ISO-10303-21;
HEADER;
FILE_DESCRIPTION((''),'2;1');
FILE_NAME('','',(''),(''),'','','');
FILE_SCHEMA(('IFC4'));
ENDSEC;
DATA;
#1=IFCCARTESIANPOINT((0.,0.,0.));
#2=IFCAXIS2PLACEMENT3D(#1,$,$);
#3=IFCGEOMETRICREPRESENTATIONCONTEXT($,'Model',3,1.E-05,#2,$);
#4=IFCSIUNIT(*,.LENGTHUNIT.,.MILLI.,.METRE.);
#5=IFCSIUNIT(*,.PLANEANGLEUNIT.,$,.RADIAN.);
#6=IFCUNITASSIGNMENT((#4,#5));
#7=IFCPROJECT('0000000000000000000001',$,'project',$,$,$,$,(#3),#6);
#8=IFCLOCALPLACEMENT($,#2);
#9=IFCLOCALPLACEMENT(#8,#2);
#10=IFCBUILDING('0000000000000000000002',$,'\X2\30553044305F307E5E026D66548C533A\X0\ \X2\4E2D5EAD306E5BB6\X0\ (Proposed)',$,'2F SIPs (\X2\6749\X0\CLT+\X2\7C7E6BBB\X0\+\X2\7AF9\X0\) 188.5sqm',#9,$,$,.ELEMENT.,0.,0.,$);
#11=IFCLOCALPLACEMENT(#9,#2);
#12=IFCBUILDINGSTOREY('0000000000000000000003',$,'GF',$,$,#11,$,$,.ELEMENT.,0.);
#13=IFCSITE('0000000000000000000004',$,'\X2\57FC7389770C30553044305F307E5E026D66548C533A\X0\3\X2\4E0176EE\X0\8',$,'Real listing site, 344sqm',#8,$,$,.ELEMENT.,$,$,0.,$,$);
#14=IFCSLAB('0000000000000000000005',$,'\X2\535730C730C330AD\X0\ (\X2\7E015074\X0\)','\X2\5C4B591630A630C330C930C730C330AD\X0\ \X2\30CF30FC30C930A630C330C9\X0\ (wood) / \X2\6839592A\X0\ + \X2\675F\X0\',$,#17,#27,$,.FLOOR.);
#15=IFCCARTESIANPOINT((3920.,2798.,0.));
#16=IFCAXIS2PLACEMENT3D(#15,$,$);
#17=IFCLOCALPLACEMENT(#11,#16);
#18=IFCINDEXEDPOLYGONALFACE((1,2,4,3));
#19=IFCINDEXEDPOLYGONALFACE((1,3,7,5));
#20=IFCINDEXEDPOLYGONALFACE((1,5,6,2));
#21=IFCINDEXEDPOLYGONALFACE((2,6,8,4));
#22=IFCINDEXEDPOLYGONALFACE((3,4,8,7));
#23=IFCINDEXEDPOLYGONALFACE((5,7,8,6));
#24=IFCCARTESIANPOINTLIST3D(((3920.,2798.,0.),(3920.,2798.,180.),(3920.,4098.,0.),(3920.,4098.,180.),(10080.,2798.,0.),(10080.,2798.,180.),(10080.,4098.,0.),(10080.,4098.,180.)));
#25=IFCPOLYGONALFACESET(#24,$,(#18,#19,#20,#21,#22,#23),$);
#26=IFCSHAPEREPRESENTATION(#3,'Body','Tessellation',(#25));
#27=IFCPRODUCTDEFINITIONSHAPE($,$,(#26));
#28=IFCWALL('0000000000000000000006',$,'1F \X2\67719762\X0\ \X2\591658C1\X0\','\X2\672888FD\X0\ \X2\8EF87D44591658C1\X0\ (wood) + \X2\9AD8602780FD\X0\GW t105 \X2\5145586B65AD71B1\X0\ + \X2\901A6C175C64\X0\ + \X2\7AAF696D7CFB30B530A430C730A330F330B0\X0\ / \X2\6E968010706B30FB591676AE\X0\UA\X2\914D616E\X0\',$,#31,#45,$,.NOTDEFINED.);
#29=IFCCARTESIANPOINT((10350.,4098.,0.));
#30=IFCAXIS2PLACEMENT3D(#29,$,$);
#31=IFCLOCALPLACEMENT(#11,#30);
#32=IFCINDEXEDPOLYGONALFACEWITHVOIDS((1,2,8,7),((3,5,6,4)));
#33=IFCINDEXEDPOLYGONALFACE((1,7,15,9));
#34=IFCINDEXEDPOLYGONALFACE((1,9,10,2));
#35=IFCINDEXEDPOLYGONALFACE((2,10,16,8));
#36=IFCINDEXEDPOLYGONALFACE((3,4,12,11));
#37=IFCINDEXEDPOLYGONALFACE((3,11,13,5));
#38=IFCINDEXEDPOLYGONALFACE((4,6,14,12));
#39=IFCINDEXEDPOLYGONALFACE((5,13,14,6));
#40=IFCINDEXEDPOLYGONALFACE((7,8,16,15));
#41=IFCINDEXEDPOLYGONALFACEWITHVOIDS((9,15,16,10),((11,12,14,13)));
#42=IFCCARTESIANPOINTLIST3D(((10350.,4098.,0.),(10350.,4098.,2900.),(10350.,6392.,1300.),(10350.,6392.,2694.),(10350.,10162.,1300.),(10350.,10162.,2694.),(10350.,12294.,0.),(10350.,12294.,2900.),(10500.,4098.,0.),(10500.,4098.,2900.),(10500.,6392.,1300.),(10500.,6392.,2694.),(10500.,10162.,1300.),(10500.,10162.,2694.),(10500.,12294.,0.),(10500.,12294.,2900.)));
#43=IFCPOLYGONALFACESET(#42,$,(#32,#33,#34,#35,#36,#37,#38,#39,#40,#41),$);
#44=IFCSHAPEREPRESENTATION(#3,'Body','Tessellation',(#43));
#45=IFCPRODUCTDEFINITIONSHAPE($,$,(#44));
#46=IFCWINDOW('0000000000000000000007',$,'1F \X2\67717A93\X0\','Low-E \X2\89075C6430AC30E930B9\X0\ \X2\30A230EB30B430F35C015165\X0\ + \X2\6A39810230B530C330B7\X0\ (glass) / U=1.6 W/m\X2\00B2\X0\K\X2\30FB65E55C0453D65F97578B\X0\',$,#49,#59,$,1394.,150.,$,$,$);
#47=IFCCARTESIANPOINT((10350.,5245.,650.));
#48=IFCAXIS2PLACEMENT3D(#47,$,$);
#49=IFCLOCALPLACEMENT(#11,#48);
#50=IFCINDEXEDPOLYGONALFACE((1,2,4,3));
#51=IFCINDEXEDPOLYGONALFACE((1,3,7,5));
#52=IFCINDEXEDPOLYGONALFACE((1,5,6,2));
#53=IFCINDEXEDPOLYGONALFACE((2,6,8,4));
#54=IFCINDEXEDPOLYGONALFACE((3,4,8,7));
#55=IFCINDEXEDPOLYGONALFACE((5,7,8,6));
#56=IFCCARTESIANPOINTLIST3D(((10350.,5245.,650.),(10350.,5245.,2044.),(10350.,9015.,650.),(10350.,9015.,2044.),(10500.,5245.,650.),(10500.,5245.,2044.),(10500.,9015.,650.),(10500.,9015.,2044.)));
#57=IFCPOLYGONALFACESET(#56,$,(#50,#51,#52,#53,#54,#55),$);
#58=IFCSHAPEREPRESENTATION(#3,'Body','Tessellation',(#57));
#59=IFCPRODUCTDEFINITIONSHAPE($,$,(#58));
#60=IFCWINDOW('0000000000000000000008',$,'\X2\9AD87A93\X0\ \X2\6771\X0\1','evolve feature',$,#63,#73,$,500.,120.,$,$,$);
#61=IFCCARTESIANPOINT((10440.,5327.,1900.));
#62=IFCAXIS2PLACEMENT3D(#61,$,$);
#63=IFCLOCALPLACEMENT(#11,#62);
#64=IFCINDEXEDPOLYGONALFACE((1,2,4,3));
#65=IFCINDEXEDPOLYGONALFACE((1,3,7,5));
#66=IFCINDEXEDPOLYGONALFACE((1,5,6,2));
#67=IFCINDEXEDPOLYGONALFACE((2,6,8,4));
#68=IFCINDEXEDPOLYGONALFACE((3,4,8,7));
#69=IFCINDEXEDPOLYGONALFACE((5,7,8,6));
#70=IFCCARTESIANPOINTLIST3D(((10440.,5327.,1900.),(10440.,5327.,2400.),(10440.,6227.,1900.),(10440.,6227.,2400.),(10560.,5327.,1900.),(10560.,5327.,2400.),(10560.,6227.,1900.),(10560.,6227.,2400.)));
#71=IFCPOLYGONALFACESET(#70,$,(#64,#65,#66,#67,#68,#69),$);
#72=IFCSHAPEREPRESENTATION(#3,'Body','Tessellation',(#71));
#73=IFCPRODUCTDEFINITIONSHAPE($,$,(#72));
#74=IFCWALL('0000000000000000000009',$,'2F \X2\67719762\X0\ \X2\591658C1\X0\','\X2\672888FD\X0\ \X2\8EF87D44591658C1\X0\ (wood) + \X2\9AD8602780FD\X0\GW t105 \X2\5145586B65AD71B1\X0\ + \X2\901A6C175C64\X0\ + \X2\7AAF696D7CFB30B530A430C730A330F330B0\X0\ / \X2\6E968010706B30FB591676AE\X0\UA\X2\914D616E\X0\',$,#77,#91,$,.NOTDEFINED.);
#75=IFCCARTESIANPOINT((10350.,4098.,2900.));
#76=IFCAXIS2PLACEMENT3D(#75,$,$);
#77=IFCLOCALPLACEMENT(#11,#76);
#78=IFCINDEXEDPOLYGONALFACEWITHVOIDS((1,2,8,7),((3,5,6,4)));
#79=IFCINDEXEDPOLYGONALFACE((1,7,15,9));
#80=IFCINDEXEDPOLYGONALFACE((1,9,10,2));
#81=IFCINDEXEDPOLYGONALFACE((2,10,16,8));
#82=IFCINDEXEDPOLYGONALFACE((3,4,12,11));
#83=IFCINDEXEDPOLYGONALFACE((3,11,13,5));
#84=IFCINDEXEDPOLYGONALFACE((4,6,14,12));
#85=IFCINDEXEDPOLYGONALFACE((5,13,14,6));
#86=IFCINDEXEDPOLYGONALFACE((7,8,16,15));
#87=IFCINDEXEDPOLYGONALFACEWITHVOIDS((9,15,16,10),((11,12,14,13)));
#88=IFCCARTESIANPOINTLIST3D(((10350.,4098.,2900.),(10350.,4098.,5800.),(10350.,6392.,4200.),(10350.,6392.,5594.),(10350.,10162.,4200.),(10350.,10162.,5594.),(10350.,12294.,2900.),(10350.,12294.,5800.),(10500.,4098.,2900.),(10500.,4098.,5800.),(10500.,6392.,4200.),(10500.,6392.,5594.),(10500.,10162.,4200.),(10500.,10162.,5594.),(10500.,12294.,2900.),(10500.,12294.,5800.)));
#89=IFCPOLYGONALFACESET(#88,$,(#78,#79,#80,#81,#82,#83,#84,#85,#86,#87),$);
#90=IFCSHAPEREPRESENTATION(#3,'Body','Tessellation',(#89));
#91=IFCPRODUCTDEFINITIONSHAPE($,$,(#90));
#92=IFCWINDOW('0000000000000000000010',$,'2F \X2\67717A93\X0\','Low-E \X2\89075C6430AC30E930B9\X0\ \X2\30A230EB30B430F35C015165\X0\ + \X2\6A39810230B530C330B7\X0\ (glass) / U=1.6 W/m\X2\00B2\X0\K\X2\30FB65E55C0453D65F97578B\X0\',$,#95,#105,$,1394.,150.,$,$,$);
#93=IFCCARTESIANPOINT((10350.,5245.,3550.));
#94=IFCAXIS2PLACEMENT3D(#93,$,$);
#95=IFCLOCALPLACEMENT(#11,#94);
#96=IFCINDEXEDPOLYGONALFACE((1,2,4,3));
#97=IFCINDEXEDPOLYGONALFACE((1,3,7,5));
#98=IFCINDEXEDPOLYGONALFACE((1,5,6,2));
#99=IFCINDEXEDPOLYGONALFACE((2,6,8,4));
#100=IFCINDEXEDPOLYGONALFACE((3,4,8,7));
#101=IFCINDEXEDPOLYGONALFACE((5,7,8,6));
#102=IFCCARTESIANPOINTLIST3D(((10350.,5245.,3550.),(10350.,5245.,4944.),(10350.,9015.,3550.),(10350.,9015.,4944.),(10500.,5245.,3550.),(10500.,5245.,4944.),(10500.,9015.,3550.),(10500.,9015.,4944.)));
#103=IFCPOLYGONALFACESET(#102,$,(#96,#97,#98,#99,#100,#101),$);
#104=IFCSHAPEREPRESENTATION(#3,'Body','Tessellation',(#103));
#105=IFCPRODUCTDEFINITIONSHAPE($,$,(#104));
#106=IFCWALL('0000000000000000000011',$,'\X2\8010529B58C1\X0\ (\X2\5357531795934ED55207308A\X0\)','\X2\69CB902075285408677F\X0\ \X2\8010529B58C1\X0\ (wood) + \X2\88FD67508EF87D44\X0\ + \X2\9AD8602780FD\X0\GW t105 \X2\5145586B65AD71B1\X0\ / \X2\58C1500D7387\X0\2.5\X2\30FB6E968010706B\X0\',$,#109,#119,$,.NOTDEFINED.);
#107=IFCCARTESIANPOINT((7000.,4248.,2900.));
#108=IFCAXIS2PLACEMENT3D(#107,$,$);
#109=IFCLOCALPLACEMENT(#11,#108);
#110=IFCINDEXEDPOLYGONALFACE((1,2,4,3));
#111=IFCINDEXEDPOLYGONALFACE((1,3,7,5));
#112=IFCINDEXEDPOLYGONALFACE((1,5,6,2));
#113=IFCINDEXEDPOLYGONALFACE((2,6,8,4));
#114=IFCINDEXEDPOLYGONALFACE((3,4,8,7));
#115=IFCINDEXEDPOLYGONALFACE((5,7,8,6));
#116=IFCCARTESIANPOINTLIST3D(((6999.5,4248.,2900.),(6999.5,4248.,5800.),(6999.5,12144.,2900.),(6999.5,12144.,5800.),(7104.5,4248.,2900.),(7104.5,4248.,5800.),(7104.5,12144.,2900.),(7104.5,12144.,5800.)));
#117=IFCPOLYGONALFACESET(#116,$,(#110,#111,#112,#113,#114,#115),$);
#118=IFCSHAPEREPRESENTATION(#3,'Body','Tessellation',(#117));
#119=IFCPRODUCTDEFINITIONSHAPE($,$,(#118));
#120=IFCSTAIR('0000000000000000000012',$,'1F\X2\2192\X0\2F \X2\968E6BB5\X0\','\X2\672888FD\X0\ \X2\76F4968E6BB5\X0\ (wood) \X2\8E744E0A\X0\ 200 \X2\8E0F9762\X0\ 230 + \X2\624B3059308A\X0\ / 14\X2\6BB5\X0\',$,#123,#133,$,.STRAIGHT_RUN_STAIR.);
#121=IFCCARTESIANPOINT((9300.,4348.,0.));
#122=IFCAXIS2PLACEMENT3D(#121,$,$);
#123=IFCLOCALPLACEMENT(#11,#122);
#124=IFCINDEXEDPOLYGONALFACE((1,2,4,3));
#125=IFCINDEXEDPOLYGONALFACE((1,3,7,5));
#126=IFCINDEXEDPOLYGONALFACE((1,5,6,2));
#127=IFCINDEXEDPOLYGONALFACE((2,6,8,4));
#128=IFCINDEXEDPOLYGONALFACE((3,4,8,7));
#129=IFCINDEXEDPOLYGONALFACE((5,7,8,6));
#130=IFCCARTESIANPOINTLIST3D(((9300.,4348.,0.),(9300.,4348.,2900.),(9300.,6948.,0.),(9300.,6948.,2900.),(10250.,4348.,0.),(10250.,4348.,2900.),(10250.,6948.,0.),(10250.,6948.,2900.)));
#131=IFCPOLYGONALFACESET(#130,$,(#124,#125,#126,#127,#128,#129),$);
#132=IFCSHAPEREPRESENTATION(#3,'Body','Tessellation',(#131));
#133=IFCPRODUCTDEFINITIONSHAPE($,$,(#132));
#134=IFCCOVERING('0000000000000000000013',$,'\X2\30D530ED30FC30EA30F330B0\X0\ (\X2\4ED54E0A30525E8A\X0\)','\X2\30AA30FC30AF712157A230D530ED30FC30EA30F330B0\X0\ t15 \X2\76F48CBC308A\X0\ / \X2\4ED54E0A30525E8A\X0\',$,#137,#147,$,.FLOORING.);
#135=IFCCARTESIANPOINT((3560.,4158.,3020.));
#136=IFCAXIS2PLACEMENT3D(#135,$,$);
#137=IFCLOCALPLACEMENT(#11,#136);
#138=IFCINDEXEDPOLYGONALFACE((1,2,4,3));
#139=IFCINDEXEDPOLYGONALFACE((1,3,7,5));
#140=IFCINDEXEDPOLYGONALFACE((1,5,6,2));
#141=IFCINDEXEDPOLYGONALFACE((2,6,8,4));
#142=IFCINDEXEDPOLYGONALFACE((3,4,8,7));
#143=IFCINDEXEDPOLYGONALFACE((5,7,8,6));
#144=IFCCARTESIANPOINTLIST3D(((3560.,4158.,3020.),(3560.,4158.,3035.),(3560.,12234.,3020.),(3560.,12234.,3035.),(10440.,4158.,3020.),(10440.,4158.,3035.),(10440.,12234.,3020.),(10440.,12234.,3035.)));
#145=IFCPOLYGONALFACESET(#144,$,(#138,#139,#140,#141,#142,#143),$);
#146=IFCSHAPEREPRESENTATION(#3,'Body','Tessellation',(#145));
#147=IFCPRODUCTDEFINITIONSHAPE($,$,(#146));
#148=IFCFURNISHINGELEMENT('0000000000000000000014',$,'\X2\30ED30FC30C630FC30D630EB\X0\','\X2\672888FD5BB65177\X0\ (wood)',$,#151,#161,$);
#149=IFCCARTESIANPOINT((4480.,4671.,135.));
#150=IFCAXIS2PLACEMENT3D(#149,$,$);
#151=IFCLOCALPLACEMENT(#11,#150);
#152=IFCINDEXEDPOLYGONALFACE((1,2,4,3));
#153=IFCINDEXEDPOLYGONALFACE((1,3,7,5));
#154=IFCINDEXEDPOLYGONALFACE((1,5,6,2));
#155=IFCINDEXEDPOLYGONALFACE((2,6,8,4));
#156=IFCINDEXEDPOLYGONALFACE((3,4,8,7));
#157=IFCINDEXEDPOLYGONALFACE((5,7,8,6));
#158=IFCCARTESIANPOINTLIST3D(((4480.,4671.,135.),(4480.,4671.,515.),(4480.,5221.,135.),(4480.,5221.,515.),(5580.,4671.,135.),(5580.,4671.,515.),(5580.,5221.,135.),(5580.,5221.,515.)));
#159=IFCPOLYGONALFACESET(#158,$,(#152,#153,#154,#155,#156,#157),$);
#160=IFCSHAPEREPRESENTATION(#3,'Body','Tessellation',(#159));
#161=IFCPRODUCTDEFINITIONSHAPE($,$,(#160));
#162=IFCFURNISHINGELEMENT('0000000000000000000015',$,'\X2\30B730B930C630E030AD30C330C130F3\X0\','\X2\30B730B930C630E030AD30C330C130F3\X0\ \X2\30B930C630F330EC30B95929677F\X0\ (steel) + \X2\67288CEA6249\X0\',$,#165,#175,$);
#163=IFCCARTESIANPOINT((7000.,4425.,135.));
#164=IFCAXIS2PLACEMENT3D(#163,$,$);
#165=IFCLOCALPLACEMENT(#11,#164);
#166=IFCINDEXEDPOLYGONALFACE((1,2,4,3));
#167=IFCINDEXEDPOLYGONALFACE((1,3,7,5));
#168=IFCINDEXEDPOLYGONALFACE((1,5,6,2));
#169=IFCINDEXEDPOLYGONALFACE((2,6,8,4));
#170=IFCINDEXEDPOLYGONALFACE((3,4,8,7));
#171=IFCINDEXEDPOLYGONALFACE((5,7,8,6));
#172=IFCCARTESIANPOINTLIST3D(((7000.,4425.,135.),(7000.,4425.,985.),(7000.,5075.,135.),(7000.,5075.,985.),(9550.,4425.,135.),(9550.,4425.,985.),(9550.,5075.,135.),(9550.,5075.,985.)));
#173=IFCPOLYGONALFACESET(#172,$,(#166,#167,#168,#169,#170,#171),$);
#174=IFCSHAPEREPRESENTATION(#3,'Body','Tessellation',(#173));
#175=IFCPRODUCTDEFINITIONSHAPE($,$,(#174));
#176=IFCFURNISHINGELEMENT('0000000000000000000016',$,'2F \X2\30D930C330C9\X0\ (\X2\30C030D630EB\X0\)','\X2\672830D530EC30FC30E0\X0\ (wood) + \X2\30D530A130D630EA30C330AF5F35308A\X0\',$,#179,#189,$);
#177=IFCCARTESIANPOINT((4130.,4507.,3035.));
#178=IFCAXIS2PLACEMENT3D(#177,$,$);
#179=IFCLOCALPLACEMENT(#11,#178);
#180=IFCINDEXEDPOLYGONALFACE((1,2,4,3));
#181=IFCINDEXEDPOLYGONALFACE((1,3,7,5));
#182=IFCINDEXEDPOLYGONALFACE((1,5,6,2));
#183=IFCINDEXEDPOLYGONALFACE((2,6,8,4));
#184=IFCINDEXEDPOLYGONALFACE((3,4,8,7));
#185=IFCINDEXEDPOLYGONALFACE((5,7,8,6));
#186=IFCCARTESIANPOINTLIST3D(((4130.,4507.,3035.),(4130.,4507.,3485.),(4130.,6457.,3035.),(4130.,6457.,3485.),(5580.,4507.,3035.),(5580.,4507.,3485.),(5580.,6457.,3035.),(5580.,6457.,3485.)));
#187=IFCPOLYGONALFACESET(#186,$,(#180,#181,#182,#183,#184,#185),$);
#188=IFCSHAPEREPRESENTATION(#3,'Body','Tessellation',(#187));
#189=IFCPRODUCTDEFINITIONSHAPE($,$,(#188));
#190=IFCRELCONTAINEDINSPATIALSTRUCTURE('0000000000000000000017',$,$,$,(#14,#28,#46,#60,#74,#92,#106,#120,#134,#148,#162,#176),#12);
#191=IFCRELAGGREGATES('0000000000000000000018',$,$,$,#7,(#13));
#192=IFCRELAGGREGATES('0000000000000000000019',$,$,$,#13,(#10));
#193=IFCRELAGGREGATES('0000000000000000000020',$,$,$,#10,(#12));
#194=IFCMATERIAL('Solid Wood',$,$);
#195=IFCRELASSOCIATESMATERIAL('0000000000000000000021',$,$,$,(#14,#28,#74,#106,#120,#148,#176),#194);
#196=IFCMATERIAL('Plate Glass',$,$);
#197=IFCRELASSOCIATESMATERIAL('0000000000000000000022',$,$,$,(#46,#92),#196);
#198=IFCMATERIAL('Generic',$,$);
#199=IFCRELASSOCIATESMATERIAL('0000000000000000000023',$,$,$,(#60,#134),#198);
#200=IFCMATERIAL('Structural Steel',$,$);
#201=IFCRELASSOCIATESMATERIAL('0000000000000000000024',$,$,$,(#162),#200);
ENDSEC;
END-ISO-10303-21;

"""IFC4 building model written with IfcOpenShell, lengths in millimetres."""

from ifc_helpers import new_model, si_unit, frame, frame_2d, origin, place, context, project, spatial, rectangle, extrude, material, element, fill, save


model = new_model("IFC4")

# Units and contexts
model_context = context("Model", 3, precision=1e-05, world=origin())
ifc_project = project(units=[si_unit("LENGTHUNIT", "METRE", prefix="MILLI"), si_unit("PLANEANGLEUNIT", "RADIAN")], contexts=[model_context])

# Site, building, storey
site_placement = place(None, origin())
site = spatial("IfcSite", under=ifc_project, at=site_placement, Name="埼玉県さいたま市浦和区3丁目8", ObjectType="Real listing site, 344sqm", CompositionType="ELEMENT", RefElevation=0.0)
building_placement = place(site_placement, origin())
building = spatial("IfcBuilding", under=site, at=building_placement, Name="さいたま市浦和区 中庭の家 (Proposed)", ObjectType="2F SIPs (杉CLT+籾殻+竹) 188.5sqm", CompositionType="ELEMENT", ElevationOfRefHeight=0.0, ElevationOfTerrain=0.0)
storey_placement = place(building_placement, origin())
storey = spatial("IfcBuildingStorey", under=building, at=storey_placement, Name="GF", CompositionType="ELEMENT", Elevation=0.0)

# Slab
ifc_material_1 = material(Name="Solid Wood")
slab_placement = place(storey_placement, frame((3920.0, 2798.0, 0.0)))
element("IfcSlab", 1, at=slab_placement, inside=storey, material=ifc_material_1, Name="南デッキ (縁側)", Description="屋外ウッドデッキ ハードウッド (wood) / 根太 + 束", PredefinedType="FLOOR", context=model_context, shape_type="SweptSolid", body=[
    extrude(rectangle(XDim=6160.0, YDim=1300.0, at=frame_2d((3080.0, 650.0))), frame((3920.0, 2798.0, 0.0)), (0.0, 0.0, 1.0), 180.0),
])

# Wall, openings, windows
wall_1_placement = place(storey_placement, frame((10350.0, 4098.0, 0.0)))
wall_1 = element("IfcWall", 2, at=wall_1_placement, inside=storey, material=ifc_material_1, Name="1F 東面 外壁", Description="木製 軸組外壁 (wood) + 高性能GW t105 充填断熱 + 通気層 + 窯業系サイディング / 準耐火・外皮UA配慮", PredefinedType="NOTDEFINED", context=model_context, shape_type="SweptSolid", body=[
    extrude(rectangle(XDim=150.0, YDim=8196.0, at=frame_2d((75.0, 4098.0))), frame((10350.0, 4098.0, 0.0)), (0.0, 0.0, 1.0), 2900.0),
])
opening_1_placement = place(storey_placement, frame((10350.0, 5245.0, 650.0)))
opening_1 = element("IfcOpeningElement", 3, at=opening_1_placement, cuts=wall_1, PredefinedType="NOTDEFINED", context=model_context, shape_type="SweptSolid", body=[
    extrude(rectangle(XDim=150.0, YDim=3770.0, at=frame_2d((75.0, 1885.0))), frame((10350.0, 5245.0, 650.0)), (0.0, 0.0, 1.0), 1394.0),
])
opening_2_placement = place(storey_placement, frame((10440.0, 5327.0, 1900.0)))
opening_2 = element("IfcOpeningElement", 4, at=opening_2_placement, cuts=wall_1, PredefinedType="NOTDEFINED", context=model_context, shape_type="SweptSolid", body=[
    extrude(rectangle(XDim=120.0, YDim=900.0, at=frame_2d((60.0, 450.0))), frame((10440.0, 5327.0, 1900.0)), (0.0, 0.0, 1.0), 500.0),
])
ifc_material_2 = material(Name="Plate Glass")
window_1_placement = place(storey_placement, frame((10350.0, 5245.0, 650.0)))
window_1 = element("IfcWindow", 5, at=window_1_placement, inside=storey, material=ifc_material_2, Name="1F 東窓", Description="Low-E 複層ガラス アルゴン封入 + 樹脂サッシ (glass) / U=1.6 W/m²K・日射取得型", OverallHeight=1394.0, OverallWidth=150.0, context=model_context, shape_type="SweptSolid", body=[
    extrude(rectangle(XDim=150.0, YDim=3770.0, at=frame_2d((75.0, 1885.0))), frame((10350.0, 5245.0, 650.0)), (0.0, 0.0, 1.0), 1394.0),
])
fill(opening_1, window_1)
ifc_material_3 = material(Name="Generic")
window_2_placement = place(storey_placement, frame((10440.0, 5327.0, 1900.0)))
window_2 = element("IfcWindow", 6, at=window_2_placement, inside=storey, material=ifc_material_3, Name="高窓 東1", Description="evolve feature", OverallHeight=500.0, OverallWidth=120.0, context=model_context, shape_type="SweptSolid", body=[
    extrude(rectangle(XDim=120.0, YDim=900.0, at=frame_2d((60.0, 450.0))), frame((10440.0, 5327.0, 1900.0)), (0.0, 0.0, 1.0), 500.0),
])
fill(opening_2, window_2)

# Wall, opening, window
wall_2_placement = place(storey_placement, frame((10350.0, 4098.0, 2900.0)))
wall_2 = element("IfcWall", 7, at=wall_2_placement, inside=storey, material=ifc_material_1, Name="2F 東面 外壁", Description="木製 軸組外壁 (wood) + 高性能GW t105 充填断熱 + 通気層 + 窯業系サイディング / 準耐火・外皮UA配慮", PredefinedType="NOTDEFINED", context=model_context, shape_type="SweptSolid", body=[
    extrude(rectangle(XDim=150.0, YDim=8196.0, at=frame_2d((75.0, 4098.0))), frame((10350.0, 4098.0, 2900.0)), (0.0, 0.0, 1.0), 2900.0),
])
opening_3_placement = place(storey_placement, frame((10350.0, 5245.0, 3550.0)))
opening_3 = element("IfcOpeningElement", 8, at=opening_3_placement, cuts=wall_2, PredefinedType="NOTDEFINED", context=model_context, shape_type="SweptSolid", body=[
    extrude(rectangle(XDim=150.0, YDim=3770.0, at=frame_2d((75.0, 1885.0))), frame((10350.0, 5245.0, 3550.0)), (0.0, 0.0, 1.0), 1394.0),
])
window_3_placement = place(storey_placement, frame((10350.0, 5245.0, 3550.0)))
window_3 = element("IfcWindow", 9, at=window_3_placement, inside=storey, material=ifc_material_2, Name="2F 東窓", Description="Low-E 複層ガラス アルゴン封入 + 樹脂サッシ (glass) / U=1.6 W/m²K・日射取得型", OverallHeight=1394.0, OverallWidth=150.0, context=model_context, shape_type="SweptSolid", body=[
    extrude(rectangle(XDim=150.0, YDim=3770.0, at=frame_2d((75.0, 1885.0))), frame((10350.0, 5245.0, 3550.0)), (0.0, 0.0, 1.0), 1394.0),
])
fill(opening_3, window_3)

# Wall
wall_3_placement = place(storey_placement, frame((7000.0, 4248.0, 2900.0)))
element("IfcWall", 10, at=wall_3_placement, inside=storey, material=ifc_material_1, Name="耐力壁 (南北間仕切り)", Description="構造用合板 耐力壁 (wood) + 製材軸組 + 高性能GW t105 充填断熱 / 壁倍率2.5・準耐火", PredefinedType="NOTDEFINED", context=model_context, shape_type="SweptSolid", body=[
    extrude(rectangle(XDim=105.0, YDim=7896.0, at=frame_2d((52.0, 3948.0))), frame((7000.0, 4248.0, 2900.0)), (0.0, 0.0, 1.0), 2900.0),
])

# Stair
stair_placement = place(storey_placement, frame((9300.0, 4348.0, 0.0)))
element("IfcStair", 11, at=stair_placement, inside=storey, material=ifc_material_1, Name="1F→2F 階段", Description="木製 直階段 (wood) 蹴上 200 踏面 230 + 手すり / 14段", PredefinedType="STRAIGHT_RUN_STAIR", context=model_context, shape_type="SweptSolid", body=[
    extrude(rectangle(XDim=950.0, YDim=2600.0, at=frame_2d((475.0, 1300.0))), frame((9300.0, 4348.0, 0.0)), (0.0, 0.0, 1.0), 2900.0),
])

# Covering
covering_placement = place(storey_placement, frame((3560.0, 4158.0, 3020.0)))
element("IfcCovering", 12, at=covering_placement, inside=storey, material=ifc_material_3, Name="フローリング (仕上げ床)", Description="オーク無垢フローリング t15 直貼り / 仕上げ床", PredefinedType="FLOORING", context=model_context, shape_type="SweptSolid", body=[
    extrude(rectangle(XDim=6880.0, YDim=8076.0, at=frame_2d((3440.0, 4038.0))), frame((3560.0, 4158.0, 3020.0)), (0.0, 0.0, 1.0), 15.0),
])

# Furnishing elements
furnishing_1_placement = place(storey_placement, frame((4480.0, 4671.0, 135.0)))
element("IfcFurnishingElement", 13, at=furnishing_1_placement, inside=storey, material=ifc_material_1, Name="ローテーブル", Description="木製家具 (wood)", context=model_context, shape_type="SweptSolid", body=[
    extrude(rectangle(XDim=1100.0, YDim=550.0, at=frame_2d((550.0, 275.0))), frame((4480.0, 4671.0, 135.0)), (0.0, 0.0, 1.0), 380.0),
])
ifc_material_4 = material(Name="Structural Steel")
furnishing_2_placement = place(storey_placement, frame((7000.0, 4425.0, 135.0)))
element("IfcFurnishingElement", 14, at=furnishing_2_placement, inside=storey, material=ifc_material_4, Name="システムキッチン", Description="システムキッチン ステンレス天板 (steel) + 木質扉", context=model_context, shape_type="SweptSolid", body=[
    extrude(rectangle(XDim=2550.0, YDim=650.0, at=frame_2d((1275.0, 325.0))), frame((7000.0, 4425.0, 135.0)), (0.0, 0.0, 1.0), 850.0),
])
furnishing_3_placement = place(storey_placement, frame((4130.0, 4507.0, 3035.0)))
element("IfcFurnishingElement", 15, at=furnishing_3_placement, inside=storey, material=ifc_material_1, Name="2F ベッド (ダブル)", Description="木フレーム (wood) + ファブリック張り", context=model_context, shape_type="SweptSolid", body=[
    extrude(rectangle(XDim=1450.0, YDim=1950.0, at=frame_2d((725.0, 975.0))), frame((4130.0, 4507.0, 3035.0)), (0.0, 0.0, 1.0), 450.0),
])

save(model, "model.ifc")
